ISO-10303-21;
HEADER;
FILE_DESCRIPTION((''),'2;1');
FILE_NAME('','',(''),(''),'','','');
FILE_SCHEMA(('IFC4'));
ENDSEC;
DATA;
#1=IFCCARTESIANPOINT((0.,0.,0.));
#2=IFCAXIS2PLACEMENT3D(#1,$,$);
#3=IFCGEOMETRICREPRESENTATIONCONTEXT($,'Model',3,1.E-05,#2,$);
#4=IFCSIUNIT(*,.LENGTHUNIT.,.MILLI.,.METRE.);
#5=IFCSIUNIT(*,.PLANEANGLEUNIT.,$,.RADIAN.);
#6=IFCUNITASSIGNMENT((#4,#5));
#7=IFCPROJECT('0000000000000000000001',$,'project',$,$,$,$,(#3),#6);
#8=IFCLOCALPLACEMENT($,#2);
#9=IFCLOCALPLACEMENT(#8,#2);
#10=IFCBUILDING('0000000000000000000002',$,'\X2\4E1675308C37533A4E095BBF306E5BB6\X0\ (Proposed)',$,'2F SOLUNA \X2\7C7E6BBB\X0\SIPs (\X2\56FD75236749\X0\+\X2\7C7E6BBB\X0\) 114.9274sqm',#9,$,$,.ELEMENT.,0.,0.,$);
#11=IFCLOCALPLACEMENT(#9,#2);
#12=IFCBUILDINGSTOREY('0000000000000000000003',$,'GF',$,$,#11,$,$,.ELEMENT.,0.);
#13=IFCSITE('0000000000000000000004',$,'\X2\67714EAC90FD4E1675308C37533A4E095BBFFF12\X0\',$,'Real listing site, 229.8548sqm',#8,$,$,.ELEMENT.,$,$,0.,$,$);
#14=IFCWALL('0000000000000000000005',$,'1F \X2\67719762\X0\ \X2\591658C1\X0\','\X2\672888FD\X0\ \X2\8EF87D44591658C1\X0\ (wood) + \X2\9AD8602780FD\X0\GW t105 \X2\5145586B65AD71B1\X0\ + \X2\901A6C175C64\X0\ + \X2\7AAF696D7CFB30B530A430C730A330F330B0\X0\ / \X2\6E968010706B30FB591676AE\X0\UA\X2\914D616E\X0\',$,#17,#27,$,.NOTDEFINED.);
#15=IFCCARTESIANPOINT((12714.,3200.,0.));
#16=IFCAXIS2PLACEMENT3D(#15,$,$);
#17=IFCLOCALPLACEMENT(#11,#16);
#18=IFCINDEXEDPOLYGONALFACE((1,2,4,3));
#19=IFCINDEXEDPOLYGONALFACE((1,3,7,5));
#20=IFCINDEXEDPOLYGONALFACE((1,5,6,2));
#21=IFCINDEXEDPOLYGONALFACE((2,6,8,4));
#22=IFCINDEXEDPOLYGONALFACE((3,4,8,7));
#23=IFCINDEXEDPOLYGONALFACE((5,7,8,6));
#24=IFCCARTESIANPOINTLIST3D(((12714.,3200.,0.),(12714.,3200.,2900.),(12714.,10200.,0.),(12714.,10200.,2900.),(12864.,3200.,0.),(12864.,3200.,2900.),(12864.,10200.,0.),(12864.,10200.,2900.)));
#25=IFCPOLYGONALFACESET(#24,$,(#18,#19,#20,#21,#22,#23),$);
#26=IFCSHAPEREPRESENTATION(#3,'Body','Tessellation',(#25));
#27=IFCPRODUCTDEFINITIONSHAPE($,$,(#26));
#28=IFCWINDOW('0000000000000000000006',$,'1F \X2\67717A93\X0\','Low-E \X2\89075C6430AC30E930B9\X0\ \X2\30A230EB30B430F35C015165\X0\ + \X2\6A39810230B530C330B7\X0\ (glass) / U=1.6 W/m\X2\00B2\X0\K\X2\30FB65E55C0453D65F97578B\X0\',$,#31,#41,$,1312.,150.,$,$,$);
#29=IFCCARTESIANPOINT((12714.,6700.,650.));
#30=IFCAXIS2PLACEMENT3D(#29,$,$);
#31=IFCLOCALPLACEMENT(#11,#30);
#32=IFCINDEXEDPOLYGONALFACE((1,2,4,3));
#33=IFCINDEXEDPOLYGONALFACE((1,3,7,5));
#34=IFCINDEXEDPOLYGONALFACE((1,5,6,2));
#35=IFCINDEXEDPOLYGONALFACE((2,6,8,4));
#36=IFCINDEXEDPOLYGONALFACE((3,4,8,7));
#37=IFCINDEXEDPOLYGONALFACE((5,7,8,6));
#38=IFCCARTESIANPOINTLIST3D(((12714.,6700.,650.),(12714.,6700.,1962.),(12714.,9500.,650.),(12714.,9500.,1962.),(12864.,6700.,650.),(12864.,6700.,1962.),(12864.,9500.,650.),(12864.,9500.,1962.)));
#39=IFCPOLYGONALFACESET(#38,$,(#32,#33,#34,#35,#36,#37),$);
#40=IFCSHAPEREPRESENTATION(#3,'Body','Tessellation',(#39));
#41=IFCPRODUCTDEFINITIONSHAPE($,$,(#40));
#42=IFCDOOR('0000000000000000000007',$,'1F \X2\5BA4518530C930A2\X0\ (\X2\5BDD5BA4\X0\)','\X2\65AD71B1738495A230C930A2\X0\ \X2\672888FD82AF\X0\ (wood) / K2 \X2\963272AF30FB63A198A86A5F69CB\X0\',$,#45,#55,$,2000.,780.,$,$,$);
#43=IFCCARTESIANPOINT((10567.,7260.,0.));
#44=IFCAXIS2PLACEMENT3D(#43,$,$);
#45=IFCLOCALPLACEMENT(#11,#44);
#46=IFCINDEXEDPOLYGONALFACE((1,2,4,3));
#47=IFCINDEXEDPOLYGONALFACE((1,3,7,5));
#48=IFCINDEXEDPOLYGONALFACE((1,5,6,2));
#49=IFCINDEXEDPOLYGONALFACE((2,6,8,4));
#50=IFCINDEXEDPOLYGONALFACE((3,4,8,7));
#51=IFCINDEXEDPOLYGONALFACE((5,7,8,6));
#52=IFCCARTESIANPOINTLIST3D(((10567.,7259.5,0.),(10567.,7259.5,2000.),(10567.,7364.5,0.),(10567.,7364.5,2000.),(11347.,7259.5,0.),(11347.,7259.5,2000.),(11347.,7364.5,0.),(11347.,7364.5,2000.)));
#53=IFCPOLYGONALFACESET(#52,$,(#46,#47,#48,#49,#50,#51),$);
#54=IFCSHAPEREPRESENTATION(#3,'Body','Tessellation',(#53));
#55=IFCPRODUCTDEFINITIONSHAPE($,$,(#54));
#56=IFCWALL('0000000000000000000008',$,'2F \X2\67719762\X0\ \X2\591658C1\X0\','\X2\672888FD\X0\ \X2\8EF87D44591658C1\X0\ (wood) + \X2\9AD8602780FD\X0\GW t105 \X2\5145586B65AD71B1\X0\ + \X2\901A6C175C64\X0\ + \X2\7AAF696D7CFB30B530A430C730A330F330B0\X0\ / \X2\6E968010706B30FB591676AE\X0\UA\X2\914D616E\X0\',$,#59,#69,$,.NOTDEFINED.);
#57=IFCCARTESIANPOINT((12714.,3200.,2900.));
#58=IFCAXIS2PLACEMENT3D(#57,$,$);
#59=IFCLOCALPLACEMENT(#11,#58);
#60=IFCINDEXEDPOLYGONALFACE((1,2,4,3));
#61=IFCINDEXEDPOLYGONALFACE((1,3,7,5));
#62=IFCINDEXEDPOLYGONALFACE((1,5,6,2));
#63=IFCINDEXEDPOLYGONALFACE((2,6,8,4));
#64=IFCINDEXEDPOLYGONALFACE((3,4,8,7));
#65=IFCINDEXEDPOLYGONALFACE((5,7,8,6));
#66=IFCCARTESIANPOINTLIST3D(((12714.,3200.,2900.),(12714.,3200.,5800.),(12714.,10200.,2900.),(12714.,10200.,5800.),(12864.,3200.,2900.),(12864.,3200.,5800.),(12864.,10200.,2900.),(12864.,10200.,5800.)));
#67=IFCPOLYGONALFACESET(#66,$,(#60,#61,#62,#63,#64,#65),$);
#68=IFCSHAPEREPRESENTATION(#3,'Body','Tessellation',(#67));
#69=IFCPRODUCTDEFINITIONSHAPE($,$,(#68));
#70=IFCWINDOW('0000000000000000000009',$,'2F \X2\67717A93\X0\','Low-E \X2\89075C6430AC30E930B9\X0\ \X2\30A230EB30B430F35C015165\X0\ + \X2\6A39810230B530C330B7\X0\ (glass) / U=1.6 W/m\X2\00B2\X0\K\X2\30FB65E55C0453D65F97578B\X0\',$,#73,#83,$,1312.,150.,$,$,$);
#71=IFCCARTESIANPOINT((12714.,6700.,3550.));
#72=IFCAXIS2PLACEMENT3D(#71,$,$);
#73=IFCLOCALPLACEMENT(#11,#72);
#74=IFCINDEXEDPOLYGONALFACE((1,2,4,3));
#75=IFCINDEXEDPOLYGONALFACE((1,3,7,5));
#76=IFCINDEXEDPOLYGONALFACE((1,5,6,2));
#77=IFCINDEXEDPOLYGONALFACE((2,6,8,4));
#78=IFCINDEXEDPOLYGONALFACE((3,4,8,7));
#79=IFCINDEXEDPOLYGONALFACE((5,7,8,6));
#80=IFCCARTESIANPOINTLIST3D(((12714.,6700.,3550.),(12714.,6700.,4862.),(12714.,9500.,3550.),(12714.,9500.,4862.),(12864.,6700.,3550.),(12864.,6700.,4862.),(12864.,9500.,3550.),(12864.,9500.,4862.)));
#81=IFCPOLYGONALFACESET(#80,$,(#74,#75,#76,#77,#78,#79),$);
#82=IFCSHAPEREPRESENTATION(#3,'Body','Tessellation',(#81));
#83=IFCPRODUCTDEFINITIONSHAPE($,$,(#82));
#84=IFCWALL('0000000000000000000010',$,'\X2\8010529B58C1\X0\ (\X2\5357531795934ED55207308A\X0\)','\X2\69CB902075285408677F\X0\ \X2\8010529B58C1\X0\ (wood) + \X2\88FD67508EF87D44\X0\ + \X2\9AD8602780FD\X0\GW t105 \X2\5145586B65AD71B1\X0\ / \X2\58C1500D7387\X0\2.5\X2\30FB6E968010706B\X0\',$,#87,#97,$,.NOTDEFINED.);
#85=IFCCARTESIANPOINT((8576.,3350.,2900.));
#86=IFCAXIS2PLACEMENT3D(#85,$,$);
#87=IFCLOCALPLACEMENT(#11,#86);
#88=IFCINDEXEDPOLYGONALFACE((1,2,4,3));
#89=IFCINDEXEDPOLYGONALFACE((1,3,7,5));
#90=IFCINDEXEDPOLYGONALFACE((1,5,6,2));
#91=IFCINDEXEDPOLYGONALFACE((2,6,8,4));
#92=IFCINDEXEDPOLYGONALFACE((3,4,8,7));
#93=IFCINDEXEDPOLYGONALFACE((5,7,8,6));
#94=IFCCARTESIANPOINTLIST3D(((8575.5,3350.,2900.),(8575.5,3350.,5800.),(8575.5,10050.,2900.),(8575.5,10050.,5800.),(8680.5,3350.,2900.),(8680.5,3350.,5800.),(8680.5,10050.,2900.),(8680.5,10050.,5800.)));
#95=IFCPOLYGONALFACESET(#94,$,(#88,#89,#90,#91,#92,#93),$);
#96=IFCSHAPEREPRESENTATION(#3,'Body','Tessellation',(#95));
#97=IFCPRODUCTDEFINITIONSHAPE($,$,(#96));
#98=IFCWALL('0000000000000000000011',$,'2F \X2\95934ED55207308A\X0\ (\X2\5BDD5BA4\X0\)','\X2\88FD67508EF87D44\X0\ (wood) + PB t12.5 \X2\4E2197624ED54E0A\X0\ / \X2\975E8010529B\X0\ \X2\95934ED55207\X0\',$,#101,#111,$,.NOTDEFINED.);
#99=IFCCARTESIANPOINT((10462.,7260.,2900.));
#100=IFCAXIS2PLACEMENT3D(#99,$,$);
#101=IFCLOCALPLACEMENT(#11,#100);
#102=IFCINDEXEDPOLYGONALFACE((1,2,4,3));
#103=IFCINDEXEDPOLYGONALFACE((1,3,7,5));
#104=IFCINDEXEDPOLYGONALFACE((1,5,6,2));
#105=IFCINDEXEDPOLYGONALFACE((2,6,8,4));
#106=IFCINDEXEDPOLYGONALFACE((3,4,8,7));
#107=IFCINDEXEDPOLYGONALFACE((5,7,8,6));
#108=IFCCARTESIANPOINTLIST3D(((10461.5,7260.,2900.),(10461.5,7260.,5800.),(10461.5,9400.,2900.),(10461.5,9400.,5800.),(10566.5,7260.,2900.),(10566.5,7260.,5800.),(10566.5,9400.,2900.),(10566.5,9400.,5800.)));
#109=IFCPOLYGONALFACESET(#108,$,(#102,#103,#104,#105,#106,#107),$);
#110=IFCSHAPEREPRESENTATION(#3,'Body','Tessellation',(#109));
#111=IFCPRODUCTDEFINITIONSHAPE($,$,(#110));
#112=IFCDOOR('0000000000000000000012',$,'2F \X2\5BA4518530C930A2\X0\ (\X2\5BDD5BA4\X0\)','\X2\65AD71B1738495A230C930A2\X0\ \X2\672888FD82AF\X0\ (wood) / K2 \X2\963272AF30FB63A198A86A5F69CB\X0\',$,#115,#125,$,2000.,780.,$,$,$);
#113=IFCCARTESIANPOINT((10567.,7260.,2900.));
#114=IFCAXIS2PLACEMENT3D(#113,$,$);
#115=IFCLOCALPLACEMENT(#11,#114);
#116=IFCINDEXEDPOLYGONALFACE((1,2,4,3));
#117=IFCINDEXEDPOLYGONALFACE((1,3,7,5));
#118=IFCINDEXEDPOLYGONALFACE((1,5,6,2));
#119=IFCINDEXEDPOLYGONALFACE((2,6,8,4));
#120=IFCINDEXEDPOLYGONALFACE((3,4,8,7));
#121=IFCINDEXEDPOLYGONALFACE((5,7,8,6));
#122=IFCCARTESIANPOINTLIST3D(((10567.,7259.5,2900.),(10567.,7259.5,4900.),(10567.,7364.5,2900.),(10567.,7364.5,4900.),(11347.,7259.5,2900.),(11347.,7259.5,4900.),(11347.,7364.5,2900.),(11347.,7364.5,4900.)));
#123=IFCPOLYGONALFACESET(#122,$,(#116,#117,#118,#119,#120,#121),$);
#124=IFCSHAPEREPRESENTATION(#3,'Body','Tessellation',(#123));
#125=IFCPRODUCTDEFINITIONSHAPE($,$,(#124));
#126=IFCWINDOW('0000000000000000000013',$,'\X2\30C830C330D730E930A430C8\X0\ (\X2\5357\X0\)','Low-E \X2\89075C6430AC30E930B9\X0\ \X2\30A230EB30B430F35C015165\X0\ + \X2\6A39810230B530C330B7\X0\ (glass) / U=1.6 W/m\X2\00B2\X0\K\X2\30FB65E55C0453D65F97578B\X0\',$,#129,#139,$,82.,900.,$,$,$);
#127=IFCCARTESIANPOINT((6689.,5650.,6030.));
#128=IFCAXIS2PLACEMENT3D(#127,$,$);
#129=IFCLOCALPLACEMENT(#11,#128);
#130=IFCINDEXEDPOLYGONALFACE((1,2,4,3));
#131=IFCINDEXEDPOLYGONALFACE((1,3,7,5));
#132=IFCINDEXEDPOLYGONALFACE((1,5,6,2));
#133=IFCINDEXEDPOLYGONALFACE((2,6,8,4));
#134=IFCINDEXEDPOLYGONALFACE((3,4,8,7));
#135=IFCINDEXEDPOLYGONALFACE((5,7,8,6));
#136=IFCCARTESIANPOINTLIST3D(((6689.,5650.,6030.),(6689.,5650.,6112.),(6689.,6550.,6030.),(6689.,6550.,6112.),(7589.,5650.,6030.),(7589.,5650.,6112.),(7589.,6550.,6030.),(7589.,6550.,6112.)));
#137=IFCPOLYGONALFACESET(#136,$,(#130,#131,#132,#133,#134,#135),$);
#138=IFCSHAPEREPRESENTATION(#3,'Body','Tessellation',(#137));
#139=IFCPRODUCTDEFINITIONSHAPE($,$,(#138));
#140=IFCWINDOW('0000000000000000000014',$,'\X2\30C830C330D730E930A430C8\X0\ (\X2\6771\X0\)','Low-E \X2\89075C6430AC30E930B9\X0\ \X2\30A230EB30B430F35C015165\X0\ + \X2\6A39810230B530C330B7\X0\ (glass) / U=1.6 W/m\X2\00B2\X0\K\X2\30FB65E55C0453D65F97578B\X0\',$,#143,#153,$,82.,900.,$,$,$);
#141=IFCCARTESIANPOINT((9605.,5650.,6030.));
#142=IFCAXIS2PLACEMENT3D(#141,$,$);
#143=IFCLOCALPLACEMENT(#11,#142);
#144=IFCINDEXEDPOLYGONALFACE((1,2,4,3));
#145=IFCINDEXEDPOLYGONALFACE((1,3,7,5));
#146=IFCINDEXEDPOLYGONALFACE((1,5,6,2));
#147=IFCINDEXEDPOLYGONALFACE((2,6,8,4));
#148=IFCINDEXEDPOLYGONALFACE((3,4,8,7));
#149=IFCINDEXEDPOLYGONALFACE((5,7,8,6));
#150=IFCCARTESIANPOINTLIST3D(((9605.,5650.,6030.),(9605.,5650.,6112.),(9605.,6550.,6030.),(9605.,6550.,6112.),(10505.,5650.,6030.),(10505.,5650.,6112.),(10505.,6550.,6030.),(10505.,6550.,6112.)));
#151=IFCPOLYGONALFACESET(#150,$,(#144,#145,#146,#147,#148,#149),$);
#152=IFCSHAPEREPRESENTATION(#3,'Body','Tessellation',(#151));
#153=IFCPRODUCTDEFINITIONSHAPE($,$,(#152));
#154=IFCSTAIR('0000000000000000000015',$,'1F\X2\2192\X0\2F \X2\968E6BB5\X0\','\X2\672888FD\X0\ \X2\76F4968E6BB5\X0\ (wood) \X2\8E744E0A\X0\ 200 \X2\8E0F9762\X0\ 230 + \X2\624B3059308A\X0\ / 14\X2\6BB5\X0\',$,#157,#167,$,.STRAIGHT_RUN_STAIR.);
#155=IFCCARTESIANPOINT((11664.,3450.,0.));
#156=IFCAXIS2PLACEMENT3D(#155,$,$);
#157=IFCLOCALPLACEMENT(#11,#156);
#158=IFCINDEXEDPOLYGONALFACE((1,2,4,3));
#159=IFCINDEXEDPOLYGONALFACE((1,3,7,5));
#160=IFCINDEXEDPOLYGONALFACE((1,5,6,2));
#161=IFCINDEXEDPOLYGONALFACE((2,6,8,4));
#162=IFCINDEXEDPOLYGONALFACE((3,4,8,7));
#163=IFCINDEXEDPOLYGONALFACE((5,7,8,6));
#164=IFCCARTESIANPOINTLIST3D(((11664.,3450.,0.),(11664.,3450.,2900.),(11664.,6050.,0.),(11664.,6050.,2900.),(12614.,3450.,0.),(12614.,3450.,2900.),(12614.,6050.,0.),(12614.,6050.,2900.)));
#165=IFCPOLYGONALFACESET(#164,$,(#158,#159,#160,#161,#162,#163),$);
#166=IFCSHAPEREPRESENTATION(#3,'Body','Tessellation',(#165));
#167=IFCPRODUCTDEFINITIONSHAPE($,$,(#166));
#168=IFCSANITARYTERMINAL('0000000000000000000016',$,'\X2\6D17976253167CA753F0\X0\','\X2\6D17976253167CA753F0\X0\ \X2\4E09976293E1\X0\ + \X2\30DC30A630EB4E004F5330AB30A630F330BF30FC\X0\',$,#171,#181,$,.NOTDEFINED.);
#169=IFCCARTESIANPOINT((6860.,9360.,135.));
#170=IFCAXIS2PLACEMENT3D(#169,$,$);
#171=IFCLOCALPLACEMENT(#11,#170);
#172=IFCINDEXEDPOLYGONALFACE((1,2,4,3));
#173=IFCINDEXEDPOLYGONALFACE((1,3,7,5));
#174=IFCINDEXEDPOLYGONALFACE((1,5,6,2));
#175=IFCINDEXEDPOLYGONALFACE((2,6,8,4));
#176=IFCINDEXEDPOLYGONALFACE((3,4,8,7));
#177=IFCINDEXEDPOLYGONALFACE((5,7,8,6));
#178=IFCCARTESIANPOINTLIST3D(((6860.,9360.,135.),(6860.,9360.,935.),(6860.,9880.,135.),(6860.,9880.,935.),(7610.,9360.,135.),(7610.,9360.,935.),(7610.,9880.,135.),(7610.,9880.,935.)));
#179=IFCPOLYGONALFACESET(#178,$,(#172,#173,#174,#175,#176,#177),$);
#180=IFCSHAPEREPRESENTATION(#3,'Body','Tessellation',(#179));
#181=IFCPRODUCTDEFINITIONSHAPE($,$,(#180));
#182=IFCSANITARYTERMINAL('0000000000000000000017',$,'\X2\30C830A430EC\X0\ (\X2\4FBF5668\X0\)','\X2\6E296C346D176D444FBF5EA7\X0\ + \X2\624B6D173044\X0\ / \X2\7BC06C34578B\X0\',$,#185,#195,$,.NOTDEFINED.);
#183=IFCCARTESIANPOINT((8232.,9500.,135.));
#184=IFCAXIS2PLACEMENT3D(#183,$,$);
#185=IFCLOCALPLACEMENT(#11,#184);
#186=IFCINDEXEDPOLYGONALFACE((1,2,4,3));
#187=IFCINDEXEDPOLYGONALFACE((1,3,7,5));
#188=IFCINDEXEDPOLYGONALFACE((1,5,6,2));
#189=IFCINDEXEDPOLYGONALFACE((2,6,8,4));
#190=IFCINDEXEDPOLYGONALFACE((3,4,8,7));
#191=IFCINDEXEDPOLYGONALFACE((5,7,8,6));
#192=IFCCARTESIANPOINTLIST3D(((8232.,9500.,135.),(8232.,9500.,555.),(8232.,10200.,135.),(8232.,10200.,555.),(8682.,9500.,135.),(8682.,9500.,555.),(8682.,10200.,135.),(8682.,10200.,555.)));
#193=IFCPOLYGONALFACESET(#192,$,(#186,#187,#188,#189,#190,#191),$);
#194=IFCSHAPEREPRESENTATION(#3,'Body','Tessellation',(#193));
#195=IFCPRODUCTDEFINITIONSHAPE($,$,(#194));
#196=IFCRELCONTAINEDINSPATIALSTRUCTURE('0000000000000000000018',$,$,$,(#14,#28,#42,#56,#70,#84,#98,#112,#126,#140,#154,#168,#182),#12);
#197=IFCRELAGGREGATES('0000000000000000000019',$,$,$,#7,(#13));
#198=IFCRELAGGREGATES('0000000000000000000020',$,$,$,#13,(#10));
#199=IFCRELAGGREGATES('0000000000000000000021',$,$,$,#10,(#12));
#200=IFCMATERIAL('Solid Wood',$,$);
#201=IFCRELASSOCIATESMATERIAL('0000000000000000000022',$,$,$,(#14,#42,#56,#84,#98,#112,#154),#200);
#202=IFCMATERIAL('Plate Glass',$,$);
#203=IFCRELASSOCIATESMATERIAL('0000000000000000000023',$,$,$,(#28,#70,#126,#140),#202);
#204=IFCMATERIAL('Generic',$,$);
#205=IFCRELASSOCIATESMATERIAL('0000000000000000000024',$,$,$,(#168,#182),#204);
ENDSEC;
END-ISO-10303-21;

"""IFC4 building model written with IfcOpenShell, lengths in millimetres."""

from ifc_helpers import new_model, si_unit, frame, frame_2d, origin, place, context, project, spatial, rectangle, extrude, material, element, fill, save


model = new_model("IFC4")

# Units and contexts
model_context = context("Model", 3, precision=1e-05, world=origin())
ifc_project = project(units=[si_unit("LENGTHUNIT", "METRE", prefix="MILLI"), si_unit("PLANEANGLEUNIT", "RADIAN")], contexts=[model_context])

# Site, building, storey
site_placement = place(None, origin())
site = spatial("IfcSite", under=ifc_project, at=site_placement, Name="東京都世田谷区三宿２", ObjectType="Real listing site, 229.8548sqm", CompositionType="ELEMENT", RefElevation=0.0)
building_placement = place(site_placement, origin())
building = spatial("IfcBuilding", under=site, at=building_placement, Name="世田谷区三宿の家 (Proposed)", ObjectType="2F SOLUNA 籾殻SIPs (国産杉+籾殻) 114.9274sqm", CompositionType="ELEMENT", ElevationOfRefHeight=0.0, ElevationOfTerrain=0.0)
storey_placement = place(building_placement, origin())
storey = spatial("IfcBuildingStorey", under=building, at=storey_placement, Name="GF", CompositionType="ELEMENT", Elevation=0.0)

# Wall, opening, window
ifc_material_1 = material(Name="Solid Wood")
wall_1_placement = place(storey_placement, frame((12714.0, 3200.0, 0.0)))
wall_1 = element("IfcWall", 1, at=wall_1_placement, inside=storey, material=ifc_material_1, Name="1F 東面 外壁", Description="木製 軸組外壁 (wood) + 高性能GW t105 充填断熱 + 通気層 + 窯業系サイディング / 準耐火・外皮UA配慮", PredefinedType="NOTDEFINED", context=model_context, shape_type="SweptSolid", body=[
    extrude(rectangle(XDim=150.0, YDim=7000.0, at=frame_2d((75.0, 3500.0))), frame((12714.0, 3200.0, 0.0)), (0.0, 0.0, 1.0), 2900.0),
])
opening_1_placement = place(storey_placement, frame((12714.0, 6700.0, 650.0)))
opening_1 = element("IfcOpeningElement", 2, at=opening_1_placement, cuts=wall_1, PredefinedType="NOTDEFINED", context=model_context, shape_type="SweptSolid", body=[
    extrude(rectangle(XDim=150.0, YDim=2800.0, at=frame_2d((75.0, 1400.0))), frame((12714.0, 6700.0, 650.0)), (0.0, 0.0, 1.0), 1312.0),
])
ifc_material_2 = material(Name="Plate Glass")
window_1_placement = place(storey_placement, frame((12714.0, 6700.0, 650.0)))
window_1 = element("IfcWindow", 3, at=window_1_placement, inside=storey, material=ifc_material_2, Name="1F 東窓", Description="Low-E 複層ガラス アルゴン封入 + 樹脂サッシ (glass) / U=1.6 W/m²K・日射取得型", OverallHeight=1312.0, OverallWidth=150.0, context=model_context, shape_type="SweptSolid", body=[
    extrude(rectangle(XDim=150.0, YDim=2800.0, at=frame_2d((75.0, 1400.0))), frame((12714.0, 6700.0, 650.0)), (0.0, 0.0, 1.0), 1312.0),
])
fill(opening_1, window_1)

# Door
door_1_placement = place(storey_placement, frame((10567.0, 7260.0, 0.0)))
element("IfcDoor", 4, at=door_1_placement, inside=storey, material=ifc_material_1, Name="1F 室内ドア (寝室)", Description="断熱玄関ドア 木製芯 (wood) / K2 防犯・採風機構", OverallHeight=2000.0, OverallWidth=780.0, context=model_context, shape_type="SweptSolid", body=[
    extrude(rectangle(XDim=780.0, YDim=105.0, at=frame_2d((390.0, 52.0))), frame((10567.0, 7260.0, 0.0)), (0.0, 0.0, 1.0), 2000.0),
])

# Wall, opening, window
wall_2_placement = place(storey_placement, frame((12714.0, 3200.0, 2900.0)))
wall_2 = element("IfcWall", 5, at=wall_2_placement, inside=storey, material=ifc_material_1, Name="2F 東面 外壁", Description="木製 軸組外壁 (wood) + 高性能GW t105 充填断熱 + 通気層 + 窯業系サイディング / 準耐火・外皮UA配慮", PredefinedType="NOTDEFINED", context=model_context, shape_type="SweptSolid", body=[
    extrude(rectangle(XDim=150.0, YDim=7000.0, at=frame_2d((75.0, 3500.0))), frame((12714.0, 3200.0, 2900.0)), (0.0, 0.0, 1.0), 2900.0),
])
opening_2_placement = place(storey_placement, frame((12714.0, 6700.0, 3550.0)))
opening_2 = element("IfcOpeningElement", 6, at=opening_2_placement, cuts=wall_2, PredefinedType="NOTDEFINED", context=model_context, shape_type="SweptSolid", body=[
    extrude(rectangle(XDim=150.0, YDim=2800.0, at=frame_2d((75.0, 1400.0))), frame((12714.0, 6700.0, 3550.0)), (0.0, 0.0, 1.0), 1312.0),
])
window_2_placement = place(storey_placement, frame((12714.0, 6700.0, 3550.0)))
window_2 = element("IfcWindow", 7, at=window_2_placement, inside=storey, material=ifc_material_2, Name="2F 東窓", Description="Low-E 複層ガラス アルゴン封入 + 樹脂サッシ (glass) / U=1.6 W/m²K・日射取得型", OverallHeight=1312.0, OverallWidth=150.0, context=model_context, shape_type="SweptSolid", body=[
    extrude(rectangle(XDim=150.0, YDim=2800.0, at=frame_2d((75.0, 1400.0))), frame((12714.0, 6700.0, 3550.0)), (0.0, 0.0, 1.0), 1312.0),
])
fill(opening_2, window_2)

# Walls
wall_3_placement = place(storey_placement, frame((8576.0, 3350.0, 2900.0)))
element("IfcWall", 8, at=wall_3_placement, inside=storey, material=ifc_material_1, Name="耐力壁 (南北間仕切り)", Description="構造用合板 耐力壁 (wood) + 製材軸組 + 高性能GW t105 充填断熱 / 壁倍率2.5・準耐火", PredefinedType="NOTDEFINED", context=model_context, shape_type="SweptSolid", body=[
    extrude(rectangle(XDim=105.0, YDim=6700.0, at=frame_2d((52.0, 3350.0))), frame((8576.0, 3350.0, 2900.0)), (0.0, 0.0, 1.0), 2900.0),
])
wall_4_placement = place(storey_placement, frame((10462.0, 7260.0, 2900.0)))
element("IfcWall", 9, at=wall_4_placement, inside=storey, material=ifc_material_1, Name="2F 間仕切り (寝室)", Description="製材軸組 (wood) + PB t12.5 両面仕上 / 非耐力 間仕切", PredefinedType="NOTDEFINED", context=model_context, shape_type="SweptSolid", body=[
    extrude(rectangle(XDim=105.0, YDim=2140.0, at=frame_2d((52.0, 1070.0))), frame((10462.0, 7260.0, 2900.0)), (0.0, 0.0, 1.0), 2900.0),
])

# Door
door_2_placement = place(storey_placement, frame((10567.0, 7260.0, 2900.0)))
element("IfcDoor", 10, at=door_2_placement, inside=storey, material=ifc_material_1, Name="2F 室内ドア (寝室)", Description="断熱玄関ドア 木製芯 (wood) / K2 防犯・採風機構", OverallHeight=2000.0, OverallWidth=780.0, context=model_context, shape_type="SweptSolid", body=[
    extrude(rectangle(XDim=780.0, YDim=105.0, at=frame_2d((390.0, 52.0))), frame((10567.0, 7260.0, 2900.0)), (0.0, 0.0, 1.0), 2000.0),
])

# Windows
window_3_placement = place(storey_placement, frame((6689.0, 5650.0, 6030.0)))
element("IfcWindow", 11, at=window_3_placement, inside=storey, material=ifc_material_2, Name="トップライト (南)", Description="Low-E 複層ガラス アルゴン封入 + 樹脂サッシ (glass) / U=1.6 W/m²K・日射取得型", OverallHeight=82.0, OverallWidth=900.0, context=model_context, shape_type="SweptSolid", body=[
    extrude(rectangle(XDim=900.0, YDim=900.0, at=frame_2d((450.0, 450.0))), frame((6689.0, 5650.0, 6030.0)), (0.0, 0.0, 1.0), 82.0),
])
window_4_placement = place(storey_placement, frame((9605.0, 5650.0, 6030.0)))
element("IfcWindow", 12, at=window_4_placement, inside=storey, material=ifc_material_2, Name="トップライト (東)", Description="Low-E 複層ガラス アルゴン封入 + 樹脂サッシ (glass) / U=1.6 W/m²K・日射取得型", OverallHeight=82.0, OverallWidth=900.0, context=model_context, shape_type="SweptSolid", body=[
    extrude(rectangle(XDim=900.0, YDim=900.0, at=frame_2d((450.0, 450.0))), frame((9605.0, 5650.0, 6030.0)), (0.0, 0.0, 1.0), 82.0),
])

# Stair
stair_placement = place(storey_placement, frame((11664.0, 3450.0, 0.0)))
element("IfcStair", 13, at=stair_placement, inside=storey, material=ifc_material_1, Name="1F→2F 階段", Description="木製 直階段 (wood) 蹴上 200 踏面 230 + 手すり / 14段", PredefinedType="STRAIGHT_RUN_STAIR", context=model_context, shape_type="SweptSolid", body=[
    extrude(rectangle(XDim=950.0, YDim=2600.0, at=frame_2d((475.0, 1300.0))), frame((11664.0, 3450.0, 0.0)), (0.0, 0.0, 1.0), 2900.0),
])

# Sanitary terminals
ifc_material_3 = material(Name="Generic")
sanitary_terminal_1_placement = place(storey_placement, frame((6860.0, 9360.0, 135.0)))
element("IfcSanitaryTerminal", 14, at=sanitary_terminal_1_placement, inside=storey, material=ifc_material_3, Name="洗面化粧台", Description="洗面化粧台 三面鏡 + ボウル一体カウンター", PredefinedType="NOTDEFINED", context=model_context, shape_type="SweptSolid", body=[
    extrude(rectangle(XDim=750.0, YDim=520.0, at=frame_2d((375.0, 260.0))), frame((6860.0, 9360.0, 135.0)), (0.0, 0.0, 1.0), 800.0),
])
sanitary_terminal_2_placement = place(storey_placement, frame((8232.0, 9500.0, 135.0)))
element("IfcSanitaryTerminal", 15, at=sanitary_terminal_2_placement, inside=storey, material=ifc_material_3, Name="トイレ (便器)", Description="温水洗浄便座 + 手洗い / 節水型", PredefinedType="NOTDEFINED", context=model_context, shape_type="SweptSolid", body=[
    extrude(rectangle(XDim=450.0, YDim=700.0, at=frame_2d((225.0, 350.0))), frame((8232.0, 9500.0, 135.0)), (0.0, 0.0, 1.0), 420.0),
])

save(model, "model.ifc")
